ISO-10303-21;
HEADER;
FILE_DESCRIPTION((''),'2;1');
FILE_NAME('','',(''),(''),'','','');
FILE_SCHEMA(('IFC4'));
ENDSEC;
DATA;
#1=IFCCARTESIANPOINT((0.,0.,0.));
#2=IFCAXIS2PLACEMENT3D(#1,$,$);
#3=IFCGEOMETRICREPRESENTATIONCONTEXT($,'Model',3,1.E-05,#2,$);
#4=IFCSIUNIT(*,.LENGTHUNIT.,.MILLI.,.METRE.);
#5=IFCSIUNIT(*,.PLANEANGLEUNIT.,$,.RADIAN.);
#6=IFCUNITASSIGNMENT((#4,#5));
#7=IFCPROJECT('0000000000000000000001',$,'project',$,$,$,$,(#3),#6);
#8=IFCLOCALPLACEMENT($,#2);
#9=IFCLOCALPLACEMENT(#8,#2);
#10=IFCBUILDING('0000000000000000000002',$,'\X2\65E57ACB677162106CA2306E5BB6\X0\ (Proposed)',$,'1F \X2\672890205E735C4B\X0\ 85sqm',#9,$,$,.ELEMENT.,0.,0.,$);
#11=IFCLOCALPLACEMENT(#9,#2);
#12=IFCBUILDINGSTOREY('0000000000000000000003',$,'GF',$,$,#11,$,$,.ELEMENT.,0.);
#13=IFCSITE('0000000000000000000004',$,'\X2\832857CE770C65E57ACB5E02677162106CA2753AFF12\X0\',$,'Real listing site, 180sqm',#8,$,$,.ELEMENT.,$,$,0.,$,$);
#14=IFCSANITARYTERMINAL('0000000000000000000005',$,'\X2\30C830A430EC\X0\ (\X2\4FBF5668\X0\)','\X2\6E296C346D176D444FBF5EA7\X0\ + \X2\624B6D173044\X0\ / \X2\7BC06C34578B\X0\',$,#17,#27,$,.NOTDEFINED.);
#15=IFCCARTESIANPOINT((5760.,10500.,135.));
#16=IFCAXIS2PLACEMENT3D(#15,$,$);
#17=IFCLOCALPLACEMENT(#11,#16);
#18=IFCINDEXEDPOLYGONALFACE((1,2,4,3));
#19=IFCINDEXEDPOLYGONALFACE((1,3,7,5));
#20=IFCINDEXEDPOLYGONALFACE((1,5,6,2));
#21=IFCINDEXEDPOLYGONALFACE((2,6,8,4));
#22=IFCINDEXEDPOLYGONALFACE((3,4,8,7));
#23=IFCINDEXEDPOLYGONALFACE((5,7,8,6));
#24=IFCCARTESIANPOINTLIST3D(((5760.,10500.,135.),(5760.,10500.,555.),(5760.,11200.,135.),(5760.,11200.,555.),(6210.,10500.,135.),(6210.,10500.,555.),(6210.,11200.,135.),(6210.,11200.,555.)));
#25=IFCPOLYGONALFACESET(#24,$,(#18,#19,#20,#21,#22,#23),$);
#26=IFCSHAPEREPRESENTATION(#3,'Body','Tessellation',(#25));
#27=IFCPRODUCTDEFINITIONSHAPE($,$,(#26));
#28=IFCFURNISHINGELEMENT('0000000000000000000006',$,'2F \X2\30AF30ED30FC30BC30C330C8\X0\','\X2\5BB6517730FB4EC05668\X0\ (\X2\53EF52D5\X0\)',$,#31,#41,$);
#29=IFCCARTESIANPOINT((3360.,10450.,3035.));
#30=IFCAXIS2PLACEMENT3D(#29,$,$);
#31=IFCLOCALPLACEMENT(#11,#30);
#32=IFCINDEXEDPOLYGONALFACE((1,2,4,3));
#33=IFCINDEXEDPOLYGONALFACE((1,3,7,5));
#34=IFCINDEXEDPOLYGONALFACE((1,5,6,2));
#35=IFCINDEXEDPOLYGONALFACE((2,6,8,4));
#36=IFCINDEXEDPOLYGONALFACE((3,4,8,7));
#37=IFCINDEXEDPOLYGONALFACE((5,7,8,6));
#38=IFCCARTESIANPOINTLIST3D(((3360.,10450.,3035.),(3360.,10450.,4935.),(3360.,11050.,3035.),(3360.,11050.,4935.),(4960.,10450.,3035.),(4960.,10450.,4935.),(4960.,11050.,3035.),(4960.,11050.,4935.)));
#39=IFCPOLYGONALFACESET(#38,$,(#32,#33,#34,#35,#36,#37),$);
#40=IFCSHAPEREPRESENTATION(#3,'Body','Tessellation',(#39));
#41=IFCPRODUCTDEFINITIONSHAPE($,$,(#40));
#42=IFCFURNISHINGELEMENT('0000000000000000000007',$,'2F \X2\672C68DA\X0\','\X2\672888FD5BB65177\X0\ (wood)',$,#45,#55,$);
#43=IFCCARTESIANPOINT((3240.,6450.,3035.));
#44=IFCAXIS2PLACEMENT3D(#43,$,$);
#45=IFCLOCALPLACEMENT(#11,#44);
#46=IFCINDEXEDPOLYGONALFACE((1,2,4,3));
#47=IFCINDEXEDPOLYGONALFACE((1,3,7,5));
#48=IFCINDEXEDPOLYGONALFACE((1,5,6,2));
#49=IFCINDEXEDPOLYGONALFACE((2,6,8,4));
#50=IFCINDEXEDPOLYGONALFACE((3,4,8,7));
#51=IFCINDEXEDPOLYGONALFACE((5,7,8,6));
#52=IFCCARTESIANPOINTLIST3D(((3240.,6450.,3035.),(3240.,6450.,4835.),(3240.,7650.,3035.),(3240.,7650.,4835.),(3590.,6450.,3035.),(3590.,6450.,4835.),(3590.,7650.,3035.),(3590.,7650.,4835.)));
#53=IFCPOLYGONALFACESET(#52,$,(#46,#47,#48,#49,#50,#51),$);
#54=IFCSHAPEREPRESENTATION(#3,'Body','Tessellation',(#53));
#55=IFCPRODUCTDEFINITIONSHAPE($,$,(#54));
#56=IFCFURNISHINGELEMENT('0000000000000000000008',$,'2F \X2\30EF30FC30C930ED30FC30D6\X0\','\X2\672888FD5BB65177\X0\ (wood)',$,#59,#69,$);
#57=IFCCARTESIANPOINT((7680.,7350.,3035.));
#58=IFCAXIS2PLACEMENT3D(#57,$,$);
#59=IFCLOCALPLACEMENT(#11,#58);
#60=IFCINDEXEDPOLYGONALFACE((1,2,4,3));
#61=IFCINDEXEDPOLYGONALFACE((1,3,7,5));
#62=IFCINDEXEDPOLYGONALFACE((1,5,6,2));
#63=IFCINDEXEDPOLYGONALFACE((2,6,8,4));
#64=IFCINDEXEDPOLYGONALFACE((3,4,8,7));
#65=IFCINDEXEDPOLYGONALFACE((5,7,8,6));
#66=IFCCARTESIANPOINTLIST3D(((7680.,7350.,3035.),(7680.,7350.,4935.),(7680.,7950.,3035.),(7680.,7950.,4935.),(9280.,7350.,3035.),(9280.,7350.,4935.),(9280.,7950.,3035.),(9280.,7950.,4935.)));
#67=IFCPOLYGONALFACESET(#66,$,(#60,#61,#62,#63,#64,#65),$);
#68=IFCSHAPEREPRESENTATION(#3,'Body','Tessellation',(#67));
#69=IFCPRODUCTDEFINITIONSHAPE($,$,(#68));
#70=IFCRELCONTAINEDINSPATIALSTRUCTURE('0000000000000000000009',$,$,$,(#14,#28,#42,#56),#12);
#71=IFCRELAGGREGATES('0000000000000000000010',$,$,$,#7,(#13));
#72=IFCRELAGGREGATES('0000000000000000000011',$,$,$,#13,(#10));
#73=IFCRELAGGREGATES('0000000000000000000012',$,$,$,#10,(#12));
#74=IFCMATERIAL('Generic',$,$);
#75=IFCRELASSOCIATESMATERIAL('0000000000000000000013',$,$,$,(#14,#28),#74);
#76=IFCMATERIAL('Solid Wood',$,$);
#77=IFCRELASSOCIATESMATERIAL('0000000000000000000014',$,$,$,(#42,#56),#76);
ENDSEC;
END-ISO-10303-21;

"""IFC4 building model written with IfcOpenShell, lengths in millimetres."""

from ifc_helpers import new_model, si_unit, frame, frame_2d, origin, place, context, project, spatial, rectangle, extrude, material, element, save


model = new_model("IFC4")

# Units and contexts
model_context = context("Model", 3, precision=1e-05, world=origin())
ifc_project = project(units=[si_unit("LENGTHUNIT", "METRE", prefix="MILLI"), si_unit("PLANEANGLEUNIT", "RADIAN")], contexts=[model_context])

# Site, building, storey
site_placement = place(None, origin())
site = spatial("IfcSite", under=ifc_project, at=site_placement, Name="茨城県日立市東成沢町２", ObjectType="Real listing site, 180sqm", CompositionType="ELEMENT", RefElevation=0.0)
building_placement = place(site_placement, origin())
building = spatial("IfcBuilding", under=site, at=building_placement, Name="日立東成沢の家 (Proposed)", ObjectType="1F 木造平屋 85sqm", CompositionType="ELEMENT", ElevationOfRefHeight=0.0, ElevationOfTerrain=0.0)
storey_placement = place(building_placement, origin())
storey = spatial("IfcBuildingStorey", under=building, at=storey_placement, Name="GF", CompositionType="ELEMENT", Elevation=0.0)

# Shared definitions
ifc_material_1 = material(Name="Solid Wood")

# Shared definitions
ifc_material_2 = material(Name="Generic")

# Sanitary terminal
sanitary_terminal_placement = place(storey_placement, frame((5760.0, 10500.0, 135.0)))
element("IfcSanitaryTerminal", 1, at=sanitary_terminal_placement, inside=storey, material=ifc_material_2, Name="トイレ (便器)", Description="温水洗浄便座 + 手洗い / 節水型", PredefinedType="NOTDEFINED", context=model_context, shape_type="SweptSolid", body=[
    extrude(rectangle(XDim=450.0, YDim=700.0, at=frame_2d((225.0, 350.0))), frame((5760.0, 10500.0, 135.0)), (0.0, 0.0, 1.0), 420.0),
])

# Furnishing elements
furnishing_1_placement = place(storey_placement, frame((3360.0, 10450.0, 3035.0)))
element("IfcFurnishingElement", 2, at=furnishing_1_placement, inside=storey, material=ifc_material_2, Name="2F クローゼット", Description="家具・什器 (可動)", context=model_context, shape_type="SweptSolid", body=[
    extrude(rectangle(XDim=1600.0, YDim=600.0, at=frame_2d((800.0, 300.0))), frame((3360.0, 10450.0, 3035.0)), (0.0, 0.0, 1.0), 1900.0),
])
furnishing_2_placement = place(storey_placement, frame((3240.0, 6450.0, 3035.0)))
element("IfcFurnishingElement", 3, at=furnishing_2_placement, inside=storey, material=ifc_material_1, Name="2F 本棚", Description="木製家具 (wood)", context=model_context, shape_type="SweptSolid", body=[
    extrude(rectangle(XDim=350.0, YDim=1200.0, at=frame_2d((175.0, 600.0))), frame((3240.0, 6450.0, 3035.0)), (0.0, 0.0, 1.0), 1800.0),
])
furnishing_3_placement = place(storey_placement, frame((7680.0, 7350.0, 3035.0)))
element("IfcFurnishingElement", 4, at=furnishing_3_placement, inside=storey, material=ifc_material_1, Name="2F ワードローブ", Description="木製家具 (wood)", context=model_context, shape_type="SweptSolid", body=[
    extrude(rectangle(XDim=1600.0, YDim=600.0, at=frame_2d((800.0, 300.0))), frame((7680.0, 7350.0, 3035.0)), (0.0, 0.0, 1.0), 1900.0),
])

save(model, "model.ifc")
